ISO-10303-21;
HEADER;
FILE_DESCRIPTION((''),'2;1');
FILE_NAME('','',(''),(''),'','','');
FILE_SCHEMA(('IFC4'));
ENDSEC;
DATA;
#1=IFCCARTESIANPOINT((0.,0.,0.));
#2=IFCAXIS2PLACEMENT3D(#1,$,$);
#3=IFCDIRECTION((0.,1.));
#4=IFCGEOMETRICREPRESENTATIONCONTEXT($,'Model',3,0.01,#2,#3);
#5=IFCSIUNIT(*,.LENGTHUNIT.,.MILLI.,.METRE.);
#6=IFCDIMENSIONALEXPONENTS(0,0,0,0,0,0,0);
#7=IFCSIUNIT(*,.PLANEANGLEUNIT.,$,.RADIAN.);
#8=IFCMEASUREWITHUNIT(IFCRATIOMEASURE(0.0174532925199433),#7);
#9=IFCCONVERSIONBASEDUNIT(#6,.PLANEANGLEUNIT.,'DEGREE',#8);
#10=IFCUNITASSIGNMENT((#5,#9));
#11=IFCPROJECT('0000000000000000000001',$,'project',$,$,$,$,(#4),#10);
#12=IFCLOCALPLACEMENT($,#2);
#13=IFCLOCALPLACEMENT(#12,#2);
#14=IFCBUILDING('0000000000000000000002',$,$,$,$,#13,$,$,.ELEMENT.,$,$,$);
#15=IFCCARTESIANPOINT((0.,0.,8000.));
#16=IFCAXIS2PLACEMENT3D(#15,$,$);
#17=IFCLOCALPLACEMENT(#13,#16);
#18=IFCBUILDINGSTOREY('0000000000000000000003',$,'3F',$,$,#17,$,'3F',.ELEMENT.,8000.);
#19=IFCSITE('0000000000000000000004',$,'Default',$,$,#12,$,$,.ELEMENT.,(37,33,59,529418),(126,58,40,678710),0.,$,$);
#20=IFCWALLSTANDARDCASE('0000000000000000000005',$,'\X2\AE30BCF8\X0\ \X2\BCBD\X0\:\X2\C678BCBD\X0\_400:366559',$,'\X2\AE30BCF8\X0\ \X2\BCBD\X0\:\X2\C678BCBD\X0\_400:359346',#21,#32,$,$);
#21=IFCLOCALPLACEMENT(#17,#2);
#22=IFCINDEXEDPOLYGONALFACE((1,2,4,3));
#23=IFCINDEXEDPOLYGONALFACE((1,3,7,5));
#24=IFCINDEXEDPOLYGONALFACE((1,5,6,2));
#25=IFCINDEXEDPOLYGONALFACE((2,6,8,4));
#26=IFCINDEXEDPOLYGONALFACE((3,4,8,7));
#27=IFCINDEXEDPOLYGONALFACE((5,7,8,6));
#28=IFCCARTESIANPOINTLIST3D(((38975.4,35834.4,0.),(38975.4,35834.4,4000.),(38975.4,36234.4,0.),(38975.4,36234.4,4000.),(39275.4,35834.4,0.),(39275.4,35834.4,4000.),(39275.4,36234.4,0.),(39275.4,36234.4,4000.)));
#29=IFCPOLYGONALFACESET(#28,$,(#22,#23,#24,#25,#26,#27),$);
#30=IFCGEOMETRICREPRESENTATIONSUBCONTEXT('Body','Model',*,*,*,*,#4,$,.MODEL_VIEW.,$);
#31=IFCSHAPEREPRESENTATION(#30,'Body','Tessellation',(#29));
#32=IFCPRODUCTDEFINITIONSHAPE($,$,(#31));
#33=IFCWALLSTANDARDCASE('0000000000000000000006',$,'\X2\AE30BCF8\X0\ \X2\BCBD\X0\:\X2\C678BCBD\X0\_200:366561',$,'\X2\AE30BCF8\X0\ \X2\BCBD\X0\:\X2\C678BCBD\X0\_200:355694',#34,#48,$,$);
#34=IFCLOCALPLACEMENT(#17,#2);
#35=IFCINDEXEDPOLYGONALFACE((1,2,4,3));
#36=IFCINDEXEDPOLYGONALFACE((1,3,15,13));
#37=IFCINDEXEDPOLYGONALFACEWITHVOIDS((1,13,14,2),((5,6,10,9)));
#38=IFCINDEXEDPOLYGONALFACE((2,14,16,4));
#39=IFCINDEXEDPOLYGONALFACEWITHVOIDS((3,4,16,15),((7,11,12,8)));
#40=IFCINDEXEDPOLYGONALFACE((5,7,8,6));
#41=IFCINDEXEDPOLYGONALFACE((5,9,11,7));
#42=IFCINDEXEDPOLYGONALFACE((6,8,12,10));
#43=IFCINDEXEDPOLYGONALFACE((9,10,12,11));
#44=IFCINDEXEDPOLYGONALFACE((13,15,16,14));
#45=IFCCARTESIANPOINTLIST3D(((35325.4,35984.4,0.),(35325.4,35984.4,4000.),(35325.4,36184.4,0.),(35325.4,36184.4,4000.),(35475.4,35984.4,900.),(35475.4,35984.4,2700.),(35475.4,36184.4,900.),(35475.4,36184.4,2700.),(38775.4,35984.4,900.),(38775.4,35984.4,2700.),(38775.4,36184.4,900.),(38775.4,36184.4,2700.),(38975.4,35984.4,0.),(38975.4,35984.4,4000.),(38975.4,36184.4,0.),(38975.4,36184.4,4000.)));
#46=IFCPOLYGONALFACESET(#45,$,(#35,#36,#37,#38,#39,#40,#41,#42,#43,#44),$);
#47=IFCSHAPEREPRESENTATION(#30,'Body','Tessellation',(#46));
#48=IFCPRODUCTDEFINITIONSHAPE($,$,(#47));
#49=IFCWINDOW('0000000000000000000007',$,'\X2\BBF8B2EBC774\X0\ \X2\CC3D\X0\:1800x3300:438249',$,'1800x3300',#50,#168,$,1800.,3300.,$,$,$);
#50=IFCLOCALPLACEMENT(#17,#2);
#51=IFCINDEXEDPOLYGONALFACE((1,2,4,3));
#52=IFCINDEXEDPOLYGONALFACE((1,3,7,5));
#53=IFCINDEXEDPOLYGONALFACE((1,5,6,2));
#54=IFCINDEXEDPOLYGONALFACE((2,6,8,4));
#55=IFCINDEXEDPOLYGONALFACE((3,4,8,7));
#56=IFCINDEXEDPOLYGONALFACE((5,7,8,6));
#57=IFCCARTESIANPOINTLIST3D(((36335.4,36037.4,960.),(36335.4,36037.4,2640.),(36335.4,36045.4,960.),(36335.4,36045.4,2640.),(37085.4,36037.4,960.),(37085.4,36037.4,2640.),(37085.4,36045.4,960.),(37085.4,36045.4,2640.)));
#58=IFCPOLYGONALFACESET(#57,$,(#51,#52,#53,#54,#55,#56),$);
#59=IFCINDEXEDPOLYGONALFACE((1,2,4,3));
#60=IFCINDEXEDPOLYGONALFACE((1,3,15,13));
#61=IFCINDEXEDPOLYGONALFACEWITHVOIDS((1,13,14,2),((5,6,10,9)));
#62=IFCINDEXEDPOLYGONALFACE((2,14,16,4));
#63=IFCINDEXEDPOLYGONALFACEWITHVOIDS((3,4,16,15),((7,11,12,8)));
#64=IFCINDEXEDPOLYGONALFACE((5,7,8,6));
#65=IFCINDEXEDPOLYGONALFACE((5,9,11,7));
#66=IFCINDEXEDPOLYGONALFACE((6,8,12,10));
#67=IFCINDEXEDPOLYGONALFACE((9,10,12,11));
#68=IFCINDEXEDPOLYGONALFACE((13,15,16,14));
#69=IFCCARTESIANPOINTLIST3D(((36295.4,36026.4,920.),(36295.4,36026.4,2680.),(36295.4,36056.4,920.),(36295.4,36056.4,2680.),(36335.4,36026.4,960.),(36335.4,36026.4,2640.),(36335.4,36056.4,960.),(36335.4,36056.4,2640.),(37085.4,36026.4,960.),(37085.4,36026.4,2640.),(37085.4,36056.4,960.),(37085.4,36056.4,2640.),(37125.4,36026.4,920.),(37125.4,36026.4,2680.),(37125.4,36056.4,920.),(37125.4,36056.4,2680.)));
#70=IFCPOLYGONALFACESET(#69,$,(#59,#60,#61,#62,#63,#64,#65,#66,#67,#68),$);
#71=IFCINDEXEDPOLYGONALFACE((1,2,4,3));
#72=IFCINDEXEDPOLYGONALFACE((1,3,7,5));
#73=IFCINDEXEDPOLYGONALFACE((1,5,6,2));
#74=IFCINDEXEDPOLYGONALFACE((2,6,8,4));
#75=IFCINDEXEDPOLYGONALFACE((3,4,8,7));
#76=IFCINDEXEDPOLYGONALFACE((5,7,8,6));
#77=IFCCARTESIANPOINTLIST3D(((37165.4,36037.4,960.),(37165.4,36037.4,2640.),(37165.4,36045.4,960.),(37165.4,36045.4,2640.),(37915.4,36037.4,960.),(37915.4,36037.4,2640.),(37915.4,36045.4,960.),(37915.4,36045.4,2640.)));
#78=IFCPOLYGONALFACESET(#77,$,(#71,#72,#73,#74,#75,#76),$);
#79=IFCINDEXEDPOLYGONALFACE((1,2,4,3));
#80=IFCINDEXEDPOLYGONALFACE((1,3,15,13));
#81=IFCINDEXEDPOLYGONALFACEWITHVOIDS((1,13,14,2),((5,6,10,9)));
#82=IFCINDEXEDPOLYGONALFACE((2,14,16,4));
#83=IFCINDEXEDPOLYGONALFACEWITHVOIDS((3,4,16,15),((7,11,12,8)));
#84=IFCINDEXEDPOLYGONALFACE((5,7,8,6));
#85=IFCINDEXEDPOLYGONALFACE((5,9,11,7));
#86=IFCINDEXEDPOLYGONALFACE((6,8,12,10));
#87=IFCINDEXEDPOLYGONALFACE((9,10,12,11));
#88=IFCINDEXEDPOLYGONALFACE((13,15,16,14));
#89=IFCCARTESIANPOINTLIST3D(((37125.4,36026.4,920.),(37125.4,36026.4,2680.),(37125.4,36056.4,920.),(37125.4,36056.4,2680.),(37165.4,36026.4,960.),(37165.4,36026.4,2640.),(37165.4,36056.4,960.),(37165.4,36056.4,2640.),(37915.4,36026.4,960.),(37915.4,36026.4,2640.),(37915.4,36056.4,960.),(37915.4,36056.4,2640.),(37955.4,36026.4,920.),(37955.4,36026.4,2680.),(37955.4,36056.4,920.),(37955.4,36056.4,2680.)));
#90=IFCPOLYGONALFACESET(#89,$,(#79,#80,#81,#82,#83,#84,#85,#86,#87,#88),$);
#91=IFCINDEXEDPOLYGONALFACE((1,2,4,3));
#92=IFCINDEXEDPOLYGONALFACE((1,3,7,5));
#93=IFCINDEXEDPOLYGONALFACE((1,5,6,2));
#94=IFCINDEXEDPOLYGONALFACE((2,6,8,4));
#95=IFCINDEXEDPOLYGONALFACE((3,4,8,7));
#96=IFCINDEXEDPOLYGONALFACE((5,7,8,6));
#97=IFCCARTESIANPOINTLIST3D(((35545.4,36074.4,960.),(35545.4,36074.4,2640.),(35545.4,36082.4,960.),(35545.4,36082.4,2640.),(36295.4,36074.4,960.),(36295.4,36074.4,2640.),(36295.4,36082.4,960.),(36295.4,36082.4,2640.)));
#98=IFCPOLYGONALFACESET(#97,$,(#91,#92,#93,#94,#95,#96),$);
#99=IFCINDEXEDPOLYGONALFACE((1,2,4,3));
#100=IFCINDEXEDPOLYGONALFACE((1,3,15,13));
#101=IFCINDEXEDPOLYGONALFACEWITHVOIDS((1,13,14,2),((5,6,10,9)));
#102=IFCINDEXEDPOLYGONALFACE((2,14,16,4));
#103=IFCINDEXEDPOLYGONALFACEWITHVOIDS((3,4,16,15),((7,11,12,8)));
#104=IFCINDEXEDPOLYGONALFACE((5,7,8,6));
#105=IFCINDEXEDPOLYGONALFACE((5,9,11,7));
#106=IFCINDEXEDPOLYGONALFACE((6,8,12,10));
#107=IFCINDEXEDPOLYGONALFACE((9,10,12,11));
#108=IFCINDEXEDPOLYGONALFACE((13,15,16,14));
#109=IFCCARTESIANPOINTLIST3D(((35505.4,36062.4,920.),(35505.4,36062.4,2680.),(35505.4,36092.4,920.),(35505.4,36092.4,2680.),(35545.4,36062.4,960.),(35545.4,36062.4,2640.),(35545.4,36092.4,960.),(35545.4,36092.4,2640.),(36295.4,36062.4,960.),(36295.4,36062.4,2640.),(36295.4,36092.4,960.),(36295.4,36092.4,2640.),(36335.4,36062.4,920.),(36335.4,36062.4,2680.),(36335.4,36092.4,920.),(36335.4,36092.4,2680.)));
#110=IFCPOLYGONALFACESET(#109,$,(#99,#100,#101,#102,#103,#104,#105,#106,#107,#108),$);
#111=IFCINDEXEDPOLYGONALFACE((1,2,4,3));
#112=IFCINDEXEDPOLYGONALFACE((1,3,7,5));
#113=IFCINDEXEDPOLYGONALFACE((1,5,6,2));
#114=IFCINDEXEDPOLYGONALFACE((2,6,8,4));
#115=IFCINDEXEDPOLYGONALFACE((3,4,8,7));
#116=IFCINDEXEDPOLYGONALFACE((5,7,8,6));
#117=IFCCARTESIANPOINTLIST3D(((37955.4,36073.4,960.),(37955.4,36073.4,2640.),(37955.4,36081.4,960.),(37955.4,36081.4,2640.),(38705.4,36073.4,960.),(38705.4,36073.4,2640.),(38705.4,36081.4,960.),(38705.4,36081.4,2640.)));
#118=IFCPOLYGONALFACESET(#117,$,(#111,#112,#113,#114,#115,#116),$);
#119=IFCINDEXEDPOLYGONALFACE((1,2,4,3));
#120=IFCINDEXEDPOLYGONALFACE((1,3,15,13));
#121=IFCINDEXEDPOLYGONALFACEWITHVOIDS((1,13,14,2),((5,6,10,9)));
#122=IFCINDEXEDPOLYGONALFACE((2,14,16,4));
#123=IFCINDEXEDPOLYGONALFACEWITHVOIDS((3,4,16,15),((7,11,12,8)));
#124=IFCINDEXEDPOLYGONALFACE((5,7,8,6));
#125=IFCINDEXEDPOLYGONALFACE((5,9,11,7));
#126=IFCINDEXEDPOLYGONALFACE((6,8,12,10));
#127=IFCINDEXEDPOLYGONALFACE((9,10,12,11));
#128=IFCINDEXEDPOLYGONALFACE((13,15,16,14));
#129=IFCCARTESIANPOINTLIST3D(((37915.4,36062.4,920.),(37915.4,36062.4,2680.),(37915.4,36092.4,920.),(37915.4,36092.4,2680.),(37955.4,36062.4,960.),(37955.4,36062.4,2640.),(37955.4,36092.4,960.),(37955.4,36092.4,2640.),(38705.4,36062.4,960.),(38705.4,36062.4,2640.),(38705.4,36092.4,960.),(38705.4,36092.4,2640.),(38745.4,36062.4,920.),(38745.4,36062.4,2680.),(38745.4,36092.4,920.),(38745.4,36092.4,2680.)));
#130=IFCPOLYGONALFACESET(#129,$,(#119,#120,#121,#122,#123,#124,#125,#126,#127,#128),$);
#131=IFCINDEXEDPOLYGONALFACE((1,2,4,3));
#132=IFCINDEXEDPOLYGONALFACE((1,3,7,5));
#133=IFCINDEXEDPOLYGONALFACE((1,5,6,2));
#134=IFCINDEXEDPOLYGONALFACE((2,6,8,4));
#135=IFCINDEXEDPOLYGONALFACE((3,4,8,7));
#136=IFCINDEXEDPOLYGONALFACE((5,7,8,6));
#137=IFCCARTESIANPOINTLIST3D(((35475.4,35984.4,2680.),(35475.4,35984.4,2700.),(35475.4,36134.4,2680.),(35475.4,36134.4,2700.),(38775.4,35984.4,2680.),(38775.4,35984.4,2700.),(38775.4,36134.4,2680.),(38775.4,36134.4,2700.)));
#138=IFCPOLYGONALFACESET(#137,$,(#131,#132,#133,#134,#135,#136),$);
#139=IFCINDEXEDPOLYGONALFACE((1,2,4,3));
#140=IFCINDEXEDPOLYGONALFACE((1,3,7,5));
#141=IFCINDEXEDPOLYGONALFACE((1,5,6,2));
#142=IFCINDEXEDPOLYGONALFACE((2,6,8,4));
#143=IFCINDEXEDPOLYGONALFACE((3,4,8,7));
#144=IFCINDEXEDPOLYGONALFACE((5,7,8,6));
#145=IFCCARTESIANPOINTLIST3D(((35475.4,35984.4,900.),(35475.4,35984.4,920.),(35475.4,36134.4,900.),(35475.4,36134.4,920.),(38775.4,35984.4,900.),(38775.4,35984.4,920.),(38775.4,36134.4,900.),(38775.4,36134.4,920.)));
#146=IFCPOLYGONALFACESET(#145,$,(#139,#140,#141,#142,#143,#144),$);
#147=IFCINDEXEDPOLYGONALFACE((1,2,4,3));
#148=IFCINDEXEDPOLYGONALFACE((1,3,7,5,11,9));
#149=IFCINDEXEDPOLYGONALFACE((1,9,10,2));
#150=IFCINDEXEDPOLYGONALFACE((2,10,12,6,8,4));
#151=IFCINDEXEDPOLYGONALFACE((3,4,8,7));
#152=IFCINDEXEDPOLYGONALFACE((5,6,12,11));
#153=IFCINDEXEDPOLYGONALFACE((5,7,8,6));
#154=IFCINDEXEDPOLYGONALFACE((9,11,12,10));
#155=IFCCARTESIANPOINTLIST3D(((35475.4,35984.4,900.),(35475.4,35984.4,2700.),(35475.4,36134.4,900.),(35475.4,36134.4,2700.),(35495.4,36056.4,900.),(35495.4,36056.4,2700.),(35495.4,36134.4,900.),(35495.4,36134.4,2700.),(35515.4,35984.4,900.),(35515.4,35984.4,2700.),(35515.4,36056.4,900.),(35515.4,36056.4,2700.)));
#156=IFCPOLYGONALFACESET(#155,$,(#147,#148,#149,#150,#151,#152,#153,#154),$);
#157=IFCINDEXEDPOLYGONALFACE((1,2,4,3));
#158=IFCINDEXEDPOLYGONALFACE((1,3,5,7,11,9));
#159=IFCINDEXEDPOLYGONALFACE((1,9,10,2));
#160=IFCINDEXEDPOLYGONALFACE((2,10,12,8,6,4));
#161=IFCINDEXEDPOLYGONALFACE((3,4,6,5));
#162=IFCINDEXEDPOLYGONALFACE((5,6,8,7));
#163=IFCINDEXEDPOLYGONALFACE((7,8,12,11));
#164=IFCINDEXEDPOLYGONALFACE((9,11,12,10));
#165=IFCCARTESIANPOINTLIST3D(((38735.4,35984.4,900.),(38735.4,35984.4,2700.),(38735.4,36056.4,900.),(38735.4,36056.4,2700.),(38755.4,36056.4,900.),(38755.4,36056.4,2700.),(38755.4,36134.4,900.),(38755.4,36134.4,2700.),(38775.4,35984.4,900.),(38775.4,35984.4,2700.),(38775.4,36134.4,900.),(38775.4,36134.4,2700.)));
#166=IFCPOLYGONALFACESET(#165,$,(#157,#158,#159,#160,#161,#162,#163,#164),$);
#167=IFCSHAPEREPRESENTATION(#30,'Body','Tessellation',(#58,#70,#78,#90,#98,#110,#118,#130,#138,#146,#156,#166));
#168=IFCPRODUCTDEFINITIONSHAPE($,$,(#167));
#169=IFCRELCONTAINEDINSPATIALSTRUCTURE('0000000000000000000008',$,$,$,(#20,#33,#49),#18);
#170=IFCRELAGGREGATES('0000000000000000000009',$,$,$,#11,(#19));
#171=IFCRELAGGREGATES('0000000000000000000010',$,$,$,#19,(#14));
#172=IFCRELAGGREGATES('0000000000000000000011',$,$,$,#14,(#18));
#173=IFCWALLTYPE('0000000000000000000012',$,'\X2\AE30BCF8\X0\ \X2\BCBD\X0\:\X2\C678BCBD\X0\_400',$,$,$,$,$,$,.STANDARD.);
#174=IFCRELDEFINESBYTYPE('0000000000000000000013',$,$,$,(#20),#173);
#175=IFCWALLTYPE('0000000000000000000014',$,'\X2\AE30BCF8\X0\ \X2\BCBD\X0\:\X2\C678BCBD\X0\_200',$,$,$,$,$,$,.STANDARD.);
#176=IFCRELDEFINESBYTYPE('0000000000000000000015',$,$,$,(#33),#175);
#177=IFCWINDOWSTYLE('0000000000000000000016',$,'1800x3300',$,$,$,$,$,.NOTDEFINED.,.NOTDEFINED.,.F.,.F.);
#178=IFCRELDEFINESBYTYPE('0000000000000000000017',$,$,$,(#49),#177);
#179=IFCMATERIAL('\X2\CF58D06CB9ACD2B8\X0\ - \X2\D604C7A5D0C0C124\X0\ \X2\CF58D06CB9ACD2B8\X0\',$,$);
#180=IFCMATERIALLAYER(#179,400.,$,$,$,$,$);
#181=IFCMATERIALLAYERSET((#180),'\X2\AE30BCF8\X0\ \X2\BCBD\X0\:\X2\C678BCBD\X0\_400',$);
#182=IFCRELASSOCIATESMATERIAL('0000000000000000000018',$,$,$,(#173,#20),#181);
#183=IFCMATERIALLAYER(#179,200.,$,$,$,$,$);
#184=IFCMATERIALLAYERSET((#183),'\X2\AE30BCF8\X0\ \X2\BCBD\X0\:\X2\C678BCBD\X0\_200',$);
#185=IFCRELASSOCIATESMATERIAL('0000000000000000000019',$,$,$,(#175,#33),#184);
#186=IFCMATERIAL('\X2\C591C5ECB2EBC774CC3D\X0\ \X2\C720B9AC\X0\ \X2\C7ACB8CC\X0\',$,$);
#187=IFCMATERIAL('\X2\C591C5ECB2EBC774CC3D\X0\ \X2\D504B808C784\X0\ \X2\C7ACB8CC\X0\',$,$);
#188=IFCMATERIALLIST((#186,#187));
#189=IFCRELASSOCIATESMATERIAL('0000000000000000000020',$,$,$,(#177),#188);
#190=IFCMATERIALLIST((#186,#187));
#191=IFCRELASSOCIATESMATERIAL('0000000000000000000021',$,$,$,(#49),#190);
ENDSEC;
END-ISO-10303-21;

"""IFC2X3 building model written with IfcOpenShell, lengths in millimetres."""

from ifc_helpers import new_model, entity, si_unit, converted_unit, direction, frame, frame_2d, origin, origin_2d_with_axis, place, context, subcontext, project, spatial, polyline, rectangle, outline, extrude, source, transform, mapped, material, material_list, layer, layer_set, layer_usage, type_object, type_shapes, element, fill, save


model = new_model("IFC2X3")

# Units and contexts
model_context = context("Model", 3, precision=0.01, world=origin(), true_north=direction((0.0, 1.0)))
body_context = subcontext(model_context, "Body", "Model", "MODEL_VIEW")
ifc_project = project(units=[si_unit("LENGTHUNIT", "METRE", prefix="MILLI"), converted_unit("PLANEANGLEUNIT", "DEGREE", entity("IfcRatioMeasure", 0.0174532925199433), si_unit("PLANEANGLEUNIT", "RADIAN"), dimensions=[0, 0, 0, 0, 0, 0, 0])], contexts=[model_context])

# Site, building, storey
site_placement = place(None, origin())
site = spatial("IfcSite", under=ifc_project, at=site_placement, Name="Default", CompositionType="ELEMENT", RefLatitude=(37, 33, 59, 529418), RefLongitude=(126, 58, 40, 678710), RefElevation=0.0)
building_placement = place(site_placement, origin())
building = spatial("IfcBuilding", under=site, at=building_placement, CompositionType="ELEMENT")
storey_placement = place(building_placement, frame((0.0, 0.0, 8000.0)))
storey = spatial("IfcBuildingStorey", under=building, at=storey_placement, Name="3F", LongName="3F", CompositionType="ELEMENT", Elevation=8000.0)

# Wall
ifc_material_1 = material(Name="콘크리트 - 현장타설 콘크리트")
ifc_layer_1 = layer(ifc_material_1, 400.0)
ifc_layer_set_1 = layer_set([ifc_layer_1], Name="기본 벽:외벽_400")
ifc_layer_usage_1 = layer_usage(ifc_layer_set_1, "AXIS2", "NEGATIVE", 200.0)
wall_type_1 = type_object("IfcWallType", Name="기본 벽:외벽_400", PredefinedType="STANDARD", material=ifc_layer_set_1)
wall_1_placement = place(storey_placement, frame((38975.4, 36034.4, 0.0)))
element("IfcWallStandardCase", 1, at=wall_1_placement, inside=storey, type_object=wall_type_1, material=ifc_layer_usage_1, Name="기본 벽:외벽_400:366559", ObjectType="기본 벽:외벽_400:359346", context=body_context, shape_type="SweptSolid", body=[
    extrude(rectangle(XDim=300.0, YDim=400.0, at=frame_2d((150.0, 0.0), x_axis=(-1.0, 0.0))), origin(), (0.0, 0.0, 1.0), 4000.0),
])

# Wall, opening, window
ifc_layer_2 = layer(ifc_material_1, 200.0)
ifc_layer_set_2 = layer_set([ifc_layer_2], Name="기본 벽:외벽_200")
ifc_layer_usage_2 = layer_usage(ifc_layer_set_2, "AXIS2", "NEGATIVE", 100.0)
wall_type_2 = type_object("IfcWallType", Name="기본 벽:외벽_200", PredefinedType="STANDARD", material=ifc_layer_set_2)
wall_2_placement = place(storey_placement, frame((38975.4, 36084.4, 0.0), z_axis=(0.0, 0.0, 1.0), x_axis=(-1.0, 0.0, 0.0)))
wall_2 = element("IfcWallStandardCase", 2, at=wall_2_placement, inside=storey, type_object=wall_type_2, material=ifc_layer_usage_2, Name="기본 벽:외벽_200:366561", ObjectType="기본 벽:외벽_200:355694", context=body_context, shape_type="SweptSolid", body=[
    extrude(rectangle(XDim=3650.0, YDim=200.0, at=frame_2d((1825.0, 0.0), x_axis=(-1.0, 0.0))), origin(), (0.0, 0.0, 1.0), 4000.0),
])
opening_1_placement = place(wall_2_placement, frame((200.0, -100.0, 900.0)))
opening_1 = element("IfcOpeningElement", 3, at=opening_1_placement, cuts=wall_2, ObjectType="Opening", context=body_context, shape_type="SweptSolid", body=[
    extrude(rectangle(XDim=1800.0, YDim=3300.0, at=frame_2d((900.0, 1650.0), x_axis=(1.0, 0.0))), frame((0.0, 0.0, 0.0), z_axis=(0.0, 1.0, 0.0), x_axis=(0.0, 0.0, 1.0)), (0.0, 0.0, 1.0), 200.0),
])
ifc_material_2 = material(Name="양여닫이창 유리 재료")
ifc_material_3 = material(Name="양여닫이창 프레임 재료")
ifc_material_list_1 = material_list([ifc_material_2, ifc_material_3])
ifc_material_list_2 = material_list([ifc_material_2, ifc_material_3])
window_style_1 = type_object("IfcWindowStyle", Name="1800x3300", ConstructionType="NOTDEFINED", OperationType="NOTDEFINED", ParameterTakesPrecedence=False, Sizeable=False, material=ifc_material_list_2)
shared_shape_1 = source(origin(), body_context, "Body", "SweptSolid", [
    extrude(rectangle(XDim=8.0, YDim=750.0, at=frame_2d((0.0, 0.0), x_axis=(1.0, 0.0))), frame((2065.0, 143.0, 60.0), z_axis=(0.0, 0.0, 1.0), x_axis=(0.0, 1.0, 0.0)), (0.0, 0.0, 1.0), 1680.0),
    extrude(outline(polyline([(-880.0, -415.0), (880.0, -415.0), (880.0, 415.0), (-880.0, 415.0), (-880.0, -415.0)]), holes=[polyline([(840.0, -375.0), (-840.0, -375.0), (-840.0, 375.0), (840.0, 375.0), (840.0, -375.0)])]), frame((2065.0, 128.0, 900.0), z_axis=(0.0, 1.0, 0.0), x_axis=(0.0, 0.0, -1.0)), (0.0, 0.0, 1.0), 30.0),
    extrude(rectangle(XDim=8.0, YDim=750.0, at=frame_2d((0.0, 0.0), x_axis=(1.0, 0.0))), frame((1235.0, 143.0, 60.0), z_axis=(0.0, 0.0, 1.0), x_axis=(0.0, 1.0, 0.0)), (0.0, 0.0, 1.0), 1680.0),
    extrude(outline(polyline([(-880.0, -415.0), (880.0, -415.0), (880.0, 415.0), (-880.0, 415.0), (-880.0, -415.0)]), holes=[polyline([(840.0, -375.0), (-840.0, -375.0), (-840.0, 375.0), (840.0, 375.0), (840.0, -375.0)])]), frame((1235.0, 128.0, 900.0), z_axis=(0.0, 1.0, 0.0), x_axis=(0.0, 0.0, -1.0)), (0.0, 0.0, 1.0), 30.0),
    extrude(rectangle(XDim=8.0, YDim=750.0, at=frame_2d((0.0, 0.0), x_axis=(1.0, 0.0))), frame((2855.0, 106.0, 60.0), z_axis=(0.0, 0.0, 1.0), x_axis=(0.0, 1.0, 0.0)), (0.0, 0.0, 1.0), 1680.0),
    extrude(outline(polyline([(-880.0, -415.0), (880.0, -415.0), (880.0, 415.0), (-880.0, 415.0), (-880.0, -415.0)]), holes=[polyline([(840.0, -375.0), (-840.0, -375.0), (-840.0, 375.0), (840.0, 375.0), (840.0, -375.0)])]), frame((2855.0, 92.0, 900.0), z_axis=(0.0, 1.0, 0.0), x_axis=(0.0, 0.0, -1.0)), (0.0, 0.0, 1.0), 30.0),
    extrude(rectangle(XDim=8.0, YDim=750.0, at=origin_2d_with_axis()), frame((445.0, 107.0, 60.0), z_axis=(0.0, 0.0, 1.0), x_axis=(0.0, 1.0, 0.0)), (0.0, 0.0, 1.0), 1680.0),
    extrude(outline(polyline([(-880.0, -415.0), (880.0, -415.0), (880.0, 415.0), (-880.0, 415.0), (-880.0, -415.0)]), holes=[polyline([(840.0, -375.0), (-840.0, -375.0), (-840.0, 375.0), (840.0, 375.0), (840.0, -375.0)])]), frame((445.0, 92.0, 900.0), z_axis=(0.0, 1.0, 0.0), x_axis=(0.0, 0.0, -1.0)), (0.0, 0.0, 1.0), 30.0),
    extrude(rectangle(XDim=3300.0, YDim=150.0, at=origin_2d_with_axis()), frame((1650.0, 125.0, 1780.0), z_axis=(0.0, 0.0, 1.0), x_axis=(-1.0, 0.0, 0.0)), (0.0, 0.0, 1.0), 20.0),
    extrude(rectangle(XDim=3300.0, YDim=150.0, at=origin_2d_with_axis()), frame((1650.0, 125.0, 0.0), z_axis=(0.0, 0.0, 1.0), x_axis=(-1.0, 0.0, 0.0)), (0.0, 0.0, 1.0), 20.0),
    extrude(outline(polyline([(-74.0, -20.0), (-2.0, -20.0), (-2.0, 0.0), (76.0, 0.0), (76.0, 20.0), (-74.0, 20.0), (-74.0, -20.0)])), frame((3280.0, 126.0, 0.0), z_axis=(0.0, 0.0, 1.0), x_axis=(0.0, -1.0, 0.0)), (0.0, 0.0, 1.0), 1800.0),
    extrude(outline(polyline([(-20.0, -74.0), (20.0, -74.0), (20.0, 76.0), (0.0, 76.0), (0.0, -2.0), (-20.0, -2.0), (-20.0, -74.0)])), frame((20.0, 126.0, 0.0), z_axis=(0.0, 0.0, 1.0), x_axis=(-1.0, 0.0, 0.0)), (0.0, 0.0, 1.0), 1800.0),
])
type_shapes(window_style_1, [shared_shape_1])
window_1_placement = place(opening_1_placement, origin())
window_1 = element("IfcWindow", 4, at=window_1_placement, inside=storey, type_object=window_style_1, material=ifc_material_list_1, Name="미닫이 창:1800x3300:438249", ObjectType="1800x3300", OverallHeight=1800.0, OverallWidth=3300.0, context=body_context, shape_type="MappedRepresentation", body=[
    mapped(shared_shape_1, transform((0.0, 0.0, 0.0), scale=1.0)),
])
fill(opening_1, window_1)

save(model, "model.ifc")
